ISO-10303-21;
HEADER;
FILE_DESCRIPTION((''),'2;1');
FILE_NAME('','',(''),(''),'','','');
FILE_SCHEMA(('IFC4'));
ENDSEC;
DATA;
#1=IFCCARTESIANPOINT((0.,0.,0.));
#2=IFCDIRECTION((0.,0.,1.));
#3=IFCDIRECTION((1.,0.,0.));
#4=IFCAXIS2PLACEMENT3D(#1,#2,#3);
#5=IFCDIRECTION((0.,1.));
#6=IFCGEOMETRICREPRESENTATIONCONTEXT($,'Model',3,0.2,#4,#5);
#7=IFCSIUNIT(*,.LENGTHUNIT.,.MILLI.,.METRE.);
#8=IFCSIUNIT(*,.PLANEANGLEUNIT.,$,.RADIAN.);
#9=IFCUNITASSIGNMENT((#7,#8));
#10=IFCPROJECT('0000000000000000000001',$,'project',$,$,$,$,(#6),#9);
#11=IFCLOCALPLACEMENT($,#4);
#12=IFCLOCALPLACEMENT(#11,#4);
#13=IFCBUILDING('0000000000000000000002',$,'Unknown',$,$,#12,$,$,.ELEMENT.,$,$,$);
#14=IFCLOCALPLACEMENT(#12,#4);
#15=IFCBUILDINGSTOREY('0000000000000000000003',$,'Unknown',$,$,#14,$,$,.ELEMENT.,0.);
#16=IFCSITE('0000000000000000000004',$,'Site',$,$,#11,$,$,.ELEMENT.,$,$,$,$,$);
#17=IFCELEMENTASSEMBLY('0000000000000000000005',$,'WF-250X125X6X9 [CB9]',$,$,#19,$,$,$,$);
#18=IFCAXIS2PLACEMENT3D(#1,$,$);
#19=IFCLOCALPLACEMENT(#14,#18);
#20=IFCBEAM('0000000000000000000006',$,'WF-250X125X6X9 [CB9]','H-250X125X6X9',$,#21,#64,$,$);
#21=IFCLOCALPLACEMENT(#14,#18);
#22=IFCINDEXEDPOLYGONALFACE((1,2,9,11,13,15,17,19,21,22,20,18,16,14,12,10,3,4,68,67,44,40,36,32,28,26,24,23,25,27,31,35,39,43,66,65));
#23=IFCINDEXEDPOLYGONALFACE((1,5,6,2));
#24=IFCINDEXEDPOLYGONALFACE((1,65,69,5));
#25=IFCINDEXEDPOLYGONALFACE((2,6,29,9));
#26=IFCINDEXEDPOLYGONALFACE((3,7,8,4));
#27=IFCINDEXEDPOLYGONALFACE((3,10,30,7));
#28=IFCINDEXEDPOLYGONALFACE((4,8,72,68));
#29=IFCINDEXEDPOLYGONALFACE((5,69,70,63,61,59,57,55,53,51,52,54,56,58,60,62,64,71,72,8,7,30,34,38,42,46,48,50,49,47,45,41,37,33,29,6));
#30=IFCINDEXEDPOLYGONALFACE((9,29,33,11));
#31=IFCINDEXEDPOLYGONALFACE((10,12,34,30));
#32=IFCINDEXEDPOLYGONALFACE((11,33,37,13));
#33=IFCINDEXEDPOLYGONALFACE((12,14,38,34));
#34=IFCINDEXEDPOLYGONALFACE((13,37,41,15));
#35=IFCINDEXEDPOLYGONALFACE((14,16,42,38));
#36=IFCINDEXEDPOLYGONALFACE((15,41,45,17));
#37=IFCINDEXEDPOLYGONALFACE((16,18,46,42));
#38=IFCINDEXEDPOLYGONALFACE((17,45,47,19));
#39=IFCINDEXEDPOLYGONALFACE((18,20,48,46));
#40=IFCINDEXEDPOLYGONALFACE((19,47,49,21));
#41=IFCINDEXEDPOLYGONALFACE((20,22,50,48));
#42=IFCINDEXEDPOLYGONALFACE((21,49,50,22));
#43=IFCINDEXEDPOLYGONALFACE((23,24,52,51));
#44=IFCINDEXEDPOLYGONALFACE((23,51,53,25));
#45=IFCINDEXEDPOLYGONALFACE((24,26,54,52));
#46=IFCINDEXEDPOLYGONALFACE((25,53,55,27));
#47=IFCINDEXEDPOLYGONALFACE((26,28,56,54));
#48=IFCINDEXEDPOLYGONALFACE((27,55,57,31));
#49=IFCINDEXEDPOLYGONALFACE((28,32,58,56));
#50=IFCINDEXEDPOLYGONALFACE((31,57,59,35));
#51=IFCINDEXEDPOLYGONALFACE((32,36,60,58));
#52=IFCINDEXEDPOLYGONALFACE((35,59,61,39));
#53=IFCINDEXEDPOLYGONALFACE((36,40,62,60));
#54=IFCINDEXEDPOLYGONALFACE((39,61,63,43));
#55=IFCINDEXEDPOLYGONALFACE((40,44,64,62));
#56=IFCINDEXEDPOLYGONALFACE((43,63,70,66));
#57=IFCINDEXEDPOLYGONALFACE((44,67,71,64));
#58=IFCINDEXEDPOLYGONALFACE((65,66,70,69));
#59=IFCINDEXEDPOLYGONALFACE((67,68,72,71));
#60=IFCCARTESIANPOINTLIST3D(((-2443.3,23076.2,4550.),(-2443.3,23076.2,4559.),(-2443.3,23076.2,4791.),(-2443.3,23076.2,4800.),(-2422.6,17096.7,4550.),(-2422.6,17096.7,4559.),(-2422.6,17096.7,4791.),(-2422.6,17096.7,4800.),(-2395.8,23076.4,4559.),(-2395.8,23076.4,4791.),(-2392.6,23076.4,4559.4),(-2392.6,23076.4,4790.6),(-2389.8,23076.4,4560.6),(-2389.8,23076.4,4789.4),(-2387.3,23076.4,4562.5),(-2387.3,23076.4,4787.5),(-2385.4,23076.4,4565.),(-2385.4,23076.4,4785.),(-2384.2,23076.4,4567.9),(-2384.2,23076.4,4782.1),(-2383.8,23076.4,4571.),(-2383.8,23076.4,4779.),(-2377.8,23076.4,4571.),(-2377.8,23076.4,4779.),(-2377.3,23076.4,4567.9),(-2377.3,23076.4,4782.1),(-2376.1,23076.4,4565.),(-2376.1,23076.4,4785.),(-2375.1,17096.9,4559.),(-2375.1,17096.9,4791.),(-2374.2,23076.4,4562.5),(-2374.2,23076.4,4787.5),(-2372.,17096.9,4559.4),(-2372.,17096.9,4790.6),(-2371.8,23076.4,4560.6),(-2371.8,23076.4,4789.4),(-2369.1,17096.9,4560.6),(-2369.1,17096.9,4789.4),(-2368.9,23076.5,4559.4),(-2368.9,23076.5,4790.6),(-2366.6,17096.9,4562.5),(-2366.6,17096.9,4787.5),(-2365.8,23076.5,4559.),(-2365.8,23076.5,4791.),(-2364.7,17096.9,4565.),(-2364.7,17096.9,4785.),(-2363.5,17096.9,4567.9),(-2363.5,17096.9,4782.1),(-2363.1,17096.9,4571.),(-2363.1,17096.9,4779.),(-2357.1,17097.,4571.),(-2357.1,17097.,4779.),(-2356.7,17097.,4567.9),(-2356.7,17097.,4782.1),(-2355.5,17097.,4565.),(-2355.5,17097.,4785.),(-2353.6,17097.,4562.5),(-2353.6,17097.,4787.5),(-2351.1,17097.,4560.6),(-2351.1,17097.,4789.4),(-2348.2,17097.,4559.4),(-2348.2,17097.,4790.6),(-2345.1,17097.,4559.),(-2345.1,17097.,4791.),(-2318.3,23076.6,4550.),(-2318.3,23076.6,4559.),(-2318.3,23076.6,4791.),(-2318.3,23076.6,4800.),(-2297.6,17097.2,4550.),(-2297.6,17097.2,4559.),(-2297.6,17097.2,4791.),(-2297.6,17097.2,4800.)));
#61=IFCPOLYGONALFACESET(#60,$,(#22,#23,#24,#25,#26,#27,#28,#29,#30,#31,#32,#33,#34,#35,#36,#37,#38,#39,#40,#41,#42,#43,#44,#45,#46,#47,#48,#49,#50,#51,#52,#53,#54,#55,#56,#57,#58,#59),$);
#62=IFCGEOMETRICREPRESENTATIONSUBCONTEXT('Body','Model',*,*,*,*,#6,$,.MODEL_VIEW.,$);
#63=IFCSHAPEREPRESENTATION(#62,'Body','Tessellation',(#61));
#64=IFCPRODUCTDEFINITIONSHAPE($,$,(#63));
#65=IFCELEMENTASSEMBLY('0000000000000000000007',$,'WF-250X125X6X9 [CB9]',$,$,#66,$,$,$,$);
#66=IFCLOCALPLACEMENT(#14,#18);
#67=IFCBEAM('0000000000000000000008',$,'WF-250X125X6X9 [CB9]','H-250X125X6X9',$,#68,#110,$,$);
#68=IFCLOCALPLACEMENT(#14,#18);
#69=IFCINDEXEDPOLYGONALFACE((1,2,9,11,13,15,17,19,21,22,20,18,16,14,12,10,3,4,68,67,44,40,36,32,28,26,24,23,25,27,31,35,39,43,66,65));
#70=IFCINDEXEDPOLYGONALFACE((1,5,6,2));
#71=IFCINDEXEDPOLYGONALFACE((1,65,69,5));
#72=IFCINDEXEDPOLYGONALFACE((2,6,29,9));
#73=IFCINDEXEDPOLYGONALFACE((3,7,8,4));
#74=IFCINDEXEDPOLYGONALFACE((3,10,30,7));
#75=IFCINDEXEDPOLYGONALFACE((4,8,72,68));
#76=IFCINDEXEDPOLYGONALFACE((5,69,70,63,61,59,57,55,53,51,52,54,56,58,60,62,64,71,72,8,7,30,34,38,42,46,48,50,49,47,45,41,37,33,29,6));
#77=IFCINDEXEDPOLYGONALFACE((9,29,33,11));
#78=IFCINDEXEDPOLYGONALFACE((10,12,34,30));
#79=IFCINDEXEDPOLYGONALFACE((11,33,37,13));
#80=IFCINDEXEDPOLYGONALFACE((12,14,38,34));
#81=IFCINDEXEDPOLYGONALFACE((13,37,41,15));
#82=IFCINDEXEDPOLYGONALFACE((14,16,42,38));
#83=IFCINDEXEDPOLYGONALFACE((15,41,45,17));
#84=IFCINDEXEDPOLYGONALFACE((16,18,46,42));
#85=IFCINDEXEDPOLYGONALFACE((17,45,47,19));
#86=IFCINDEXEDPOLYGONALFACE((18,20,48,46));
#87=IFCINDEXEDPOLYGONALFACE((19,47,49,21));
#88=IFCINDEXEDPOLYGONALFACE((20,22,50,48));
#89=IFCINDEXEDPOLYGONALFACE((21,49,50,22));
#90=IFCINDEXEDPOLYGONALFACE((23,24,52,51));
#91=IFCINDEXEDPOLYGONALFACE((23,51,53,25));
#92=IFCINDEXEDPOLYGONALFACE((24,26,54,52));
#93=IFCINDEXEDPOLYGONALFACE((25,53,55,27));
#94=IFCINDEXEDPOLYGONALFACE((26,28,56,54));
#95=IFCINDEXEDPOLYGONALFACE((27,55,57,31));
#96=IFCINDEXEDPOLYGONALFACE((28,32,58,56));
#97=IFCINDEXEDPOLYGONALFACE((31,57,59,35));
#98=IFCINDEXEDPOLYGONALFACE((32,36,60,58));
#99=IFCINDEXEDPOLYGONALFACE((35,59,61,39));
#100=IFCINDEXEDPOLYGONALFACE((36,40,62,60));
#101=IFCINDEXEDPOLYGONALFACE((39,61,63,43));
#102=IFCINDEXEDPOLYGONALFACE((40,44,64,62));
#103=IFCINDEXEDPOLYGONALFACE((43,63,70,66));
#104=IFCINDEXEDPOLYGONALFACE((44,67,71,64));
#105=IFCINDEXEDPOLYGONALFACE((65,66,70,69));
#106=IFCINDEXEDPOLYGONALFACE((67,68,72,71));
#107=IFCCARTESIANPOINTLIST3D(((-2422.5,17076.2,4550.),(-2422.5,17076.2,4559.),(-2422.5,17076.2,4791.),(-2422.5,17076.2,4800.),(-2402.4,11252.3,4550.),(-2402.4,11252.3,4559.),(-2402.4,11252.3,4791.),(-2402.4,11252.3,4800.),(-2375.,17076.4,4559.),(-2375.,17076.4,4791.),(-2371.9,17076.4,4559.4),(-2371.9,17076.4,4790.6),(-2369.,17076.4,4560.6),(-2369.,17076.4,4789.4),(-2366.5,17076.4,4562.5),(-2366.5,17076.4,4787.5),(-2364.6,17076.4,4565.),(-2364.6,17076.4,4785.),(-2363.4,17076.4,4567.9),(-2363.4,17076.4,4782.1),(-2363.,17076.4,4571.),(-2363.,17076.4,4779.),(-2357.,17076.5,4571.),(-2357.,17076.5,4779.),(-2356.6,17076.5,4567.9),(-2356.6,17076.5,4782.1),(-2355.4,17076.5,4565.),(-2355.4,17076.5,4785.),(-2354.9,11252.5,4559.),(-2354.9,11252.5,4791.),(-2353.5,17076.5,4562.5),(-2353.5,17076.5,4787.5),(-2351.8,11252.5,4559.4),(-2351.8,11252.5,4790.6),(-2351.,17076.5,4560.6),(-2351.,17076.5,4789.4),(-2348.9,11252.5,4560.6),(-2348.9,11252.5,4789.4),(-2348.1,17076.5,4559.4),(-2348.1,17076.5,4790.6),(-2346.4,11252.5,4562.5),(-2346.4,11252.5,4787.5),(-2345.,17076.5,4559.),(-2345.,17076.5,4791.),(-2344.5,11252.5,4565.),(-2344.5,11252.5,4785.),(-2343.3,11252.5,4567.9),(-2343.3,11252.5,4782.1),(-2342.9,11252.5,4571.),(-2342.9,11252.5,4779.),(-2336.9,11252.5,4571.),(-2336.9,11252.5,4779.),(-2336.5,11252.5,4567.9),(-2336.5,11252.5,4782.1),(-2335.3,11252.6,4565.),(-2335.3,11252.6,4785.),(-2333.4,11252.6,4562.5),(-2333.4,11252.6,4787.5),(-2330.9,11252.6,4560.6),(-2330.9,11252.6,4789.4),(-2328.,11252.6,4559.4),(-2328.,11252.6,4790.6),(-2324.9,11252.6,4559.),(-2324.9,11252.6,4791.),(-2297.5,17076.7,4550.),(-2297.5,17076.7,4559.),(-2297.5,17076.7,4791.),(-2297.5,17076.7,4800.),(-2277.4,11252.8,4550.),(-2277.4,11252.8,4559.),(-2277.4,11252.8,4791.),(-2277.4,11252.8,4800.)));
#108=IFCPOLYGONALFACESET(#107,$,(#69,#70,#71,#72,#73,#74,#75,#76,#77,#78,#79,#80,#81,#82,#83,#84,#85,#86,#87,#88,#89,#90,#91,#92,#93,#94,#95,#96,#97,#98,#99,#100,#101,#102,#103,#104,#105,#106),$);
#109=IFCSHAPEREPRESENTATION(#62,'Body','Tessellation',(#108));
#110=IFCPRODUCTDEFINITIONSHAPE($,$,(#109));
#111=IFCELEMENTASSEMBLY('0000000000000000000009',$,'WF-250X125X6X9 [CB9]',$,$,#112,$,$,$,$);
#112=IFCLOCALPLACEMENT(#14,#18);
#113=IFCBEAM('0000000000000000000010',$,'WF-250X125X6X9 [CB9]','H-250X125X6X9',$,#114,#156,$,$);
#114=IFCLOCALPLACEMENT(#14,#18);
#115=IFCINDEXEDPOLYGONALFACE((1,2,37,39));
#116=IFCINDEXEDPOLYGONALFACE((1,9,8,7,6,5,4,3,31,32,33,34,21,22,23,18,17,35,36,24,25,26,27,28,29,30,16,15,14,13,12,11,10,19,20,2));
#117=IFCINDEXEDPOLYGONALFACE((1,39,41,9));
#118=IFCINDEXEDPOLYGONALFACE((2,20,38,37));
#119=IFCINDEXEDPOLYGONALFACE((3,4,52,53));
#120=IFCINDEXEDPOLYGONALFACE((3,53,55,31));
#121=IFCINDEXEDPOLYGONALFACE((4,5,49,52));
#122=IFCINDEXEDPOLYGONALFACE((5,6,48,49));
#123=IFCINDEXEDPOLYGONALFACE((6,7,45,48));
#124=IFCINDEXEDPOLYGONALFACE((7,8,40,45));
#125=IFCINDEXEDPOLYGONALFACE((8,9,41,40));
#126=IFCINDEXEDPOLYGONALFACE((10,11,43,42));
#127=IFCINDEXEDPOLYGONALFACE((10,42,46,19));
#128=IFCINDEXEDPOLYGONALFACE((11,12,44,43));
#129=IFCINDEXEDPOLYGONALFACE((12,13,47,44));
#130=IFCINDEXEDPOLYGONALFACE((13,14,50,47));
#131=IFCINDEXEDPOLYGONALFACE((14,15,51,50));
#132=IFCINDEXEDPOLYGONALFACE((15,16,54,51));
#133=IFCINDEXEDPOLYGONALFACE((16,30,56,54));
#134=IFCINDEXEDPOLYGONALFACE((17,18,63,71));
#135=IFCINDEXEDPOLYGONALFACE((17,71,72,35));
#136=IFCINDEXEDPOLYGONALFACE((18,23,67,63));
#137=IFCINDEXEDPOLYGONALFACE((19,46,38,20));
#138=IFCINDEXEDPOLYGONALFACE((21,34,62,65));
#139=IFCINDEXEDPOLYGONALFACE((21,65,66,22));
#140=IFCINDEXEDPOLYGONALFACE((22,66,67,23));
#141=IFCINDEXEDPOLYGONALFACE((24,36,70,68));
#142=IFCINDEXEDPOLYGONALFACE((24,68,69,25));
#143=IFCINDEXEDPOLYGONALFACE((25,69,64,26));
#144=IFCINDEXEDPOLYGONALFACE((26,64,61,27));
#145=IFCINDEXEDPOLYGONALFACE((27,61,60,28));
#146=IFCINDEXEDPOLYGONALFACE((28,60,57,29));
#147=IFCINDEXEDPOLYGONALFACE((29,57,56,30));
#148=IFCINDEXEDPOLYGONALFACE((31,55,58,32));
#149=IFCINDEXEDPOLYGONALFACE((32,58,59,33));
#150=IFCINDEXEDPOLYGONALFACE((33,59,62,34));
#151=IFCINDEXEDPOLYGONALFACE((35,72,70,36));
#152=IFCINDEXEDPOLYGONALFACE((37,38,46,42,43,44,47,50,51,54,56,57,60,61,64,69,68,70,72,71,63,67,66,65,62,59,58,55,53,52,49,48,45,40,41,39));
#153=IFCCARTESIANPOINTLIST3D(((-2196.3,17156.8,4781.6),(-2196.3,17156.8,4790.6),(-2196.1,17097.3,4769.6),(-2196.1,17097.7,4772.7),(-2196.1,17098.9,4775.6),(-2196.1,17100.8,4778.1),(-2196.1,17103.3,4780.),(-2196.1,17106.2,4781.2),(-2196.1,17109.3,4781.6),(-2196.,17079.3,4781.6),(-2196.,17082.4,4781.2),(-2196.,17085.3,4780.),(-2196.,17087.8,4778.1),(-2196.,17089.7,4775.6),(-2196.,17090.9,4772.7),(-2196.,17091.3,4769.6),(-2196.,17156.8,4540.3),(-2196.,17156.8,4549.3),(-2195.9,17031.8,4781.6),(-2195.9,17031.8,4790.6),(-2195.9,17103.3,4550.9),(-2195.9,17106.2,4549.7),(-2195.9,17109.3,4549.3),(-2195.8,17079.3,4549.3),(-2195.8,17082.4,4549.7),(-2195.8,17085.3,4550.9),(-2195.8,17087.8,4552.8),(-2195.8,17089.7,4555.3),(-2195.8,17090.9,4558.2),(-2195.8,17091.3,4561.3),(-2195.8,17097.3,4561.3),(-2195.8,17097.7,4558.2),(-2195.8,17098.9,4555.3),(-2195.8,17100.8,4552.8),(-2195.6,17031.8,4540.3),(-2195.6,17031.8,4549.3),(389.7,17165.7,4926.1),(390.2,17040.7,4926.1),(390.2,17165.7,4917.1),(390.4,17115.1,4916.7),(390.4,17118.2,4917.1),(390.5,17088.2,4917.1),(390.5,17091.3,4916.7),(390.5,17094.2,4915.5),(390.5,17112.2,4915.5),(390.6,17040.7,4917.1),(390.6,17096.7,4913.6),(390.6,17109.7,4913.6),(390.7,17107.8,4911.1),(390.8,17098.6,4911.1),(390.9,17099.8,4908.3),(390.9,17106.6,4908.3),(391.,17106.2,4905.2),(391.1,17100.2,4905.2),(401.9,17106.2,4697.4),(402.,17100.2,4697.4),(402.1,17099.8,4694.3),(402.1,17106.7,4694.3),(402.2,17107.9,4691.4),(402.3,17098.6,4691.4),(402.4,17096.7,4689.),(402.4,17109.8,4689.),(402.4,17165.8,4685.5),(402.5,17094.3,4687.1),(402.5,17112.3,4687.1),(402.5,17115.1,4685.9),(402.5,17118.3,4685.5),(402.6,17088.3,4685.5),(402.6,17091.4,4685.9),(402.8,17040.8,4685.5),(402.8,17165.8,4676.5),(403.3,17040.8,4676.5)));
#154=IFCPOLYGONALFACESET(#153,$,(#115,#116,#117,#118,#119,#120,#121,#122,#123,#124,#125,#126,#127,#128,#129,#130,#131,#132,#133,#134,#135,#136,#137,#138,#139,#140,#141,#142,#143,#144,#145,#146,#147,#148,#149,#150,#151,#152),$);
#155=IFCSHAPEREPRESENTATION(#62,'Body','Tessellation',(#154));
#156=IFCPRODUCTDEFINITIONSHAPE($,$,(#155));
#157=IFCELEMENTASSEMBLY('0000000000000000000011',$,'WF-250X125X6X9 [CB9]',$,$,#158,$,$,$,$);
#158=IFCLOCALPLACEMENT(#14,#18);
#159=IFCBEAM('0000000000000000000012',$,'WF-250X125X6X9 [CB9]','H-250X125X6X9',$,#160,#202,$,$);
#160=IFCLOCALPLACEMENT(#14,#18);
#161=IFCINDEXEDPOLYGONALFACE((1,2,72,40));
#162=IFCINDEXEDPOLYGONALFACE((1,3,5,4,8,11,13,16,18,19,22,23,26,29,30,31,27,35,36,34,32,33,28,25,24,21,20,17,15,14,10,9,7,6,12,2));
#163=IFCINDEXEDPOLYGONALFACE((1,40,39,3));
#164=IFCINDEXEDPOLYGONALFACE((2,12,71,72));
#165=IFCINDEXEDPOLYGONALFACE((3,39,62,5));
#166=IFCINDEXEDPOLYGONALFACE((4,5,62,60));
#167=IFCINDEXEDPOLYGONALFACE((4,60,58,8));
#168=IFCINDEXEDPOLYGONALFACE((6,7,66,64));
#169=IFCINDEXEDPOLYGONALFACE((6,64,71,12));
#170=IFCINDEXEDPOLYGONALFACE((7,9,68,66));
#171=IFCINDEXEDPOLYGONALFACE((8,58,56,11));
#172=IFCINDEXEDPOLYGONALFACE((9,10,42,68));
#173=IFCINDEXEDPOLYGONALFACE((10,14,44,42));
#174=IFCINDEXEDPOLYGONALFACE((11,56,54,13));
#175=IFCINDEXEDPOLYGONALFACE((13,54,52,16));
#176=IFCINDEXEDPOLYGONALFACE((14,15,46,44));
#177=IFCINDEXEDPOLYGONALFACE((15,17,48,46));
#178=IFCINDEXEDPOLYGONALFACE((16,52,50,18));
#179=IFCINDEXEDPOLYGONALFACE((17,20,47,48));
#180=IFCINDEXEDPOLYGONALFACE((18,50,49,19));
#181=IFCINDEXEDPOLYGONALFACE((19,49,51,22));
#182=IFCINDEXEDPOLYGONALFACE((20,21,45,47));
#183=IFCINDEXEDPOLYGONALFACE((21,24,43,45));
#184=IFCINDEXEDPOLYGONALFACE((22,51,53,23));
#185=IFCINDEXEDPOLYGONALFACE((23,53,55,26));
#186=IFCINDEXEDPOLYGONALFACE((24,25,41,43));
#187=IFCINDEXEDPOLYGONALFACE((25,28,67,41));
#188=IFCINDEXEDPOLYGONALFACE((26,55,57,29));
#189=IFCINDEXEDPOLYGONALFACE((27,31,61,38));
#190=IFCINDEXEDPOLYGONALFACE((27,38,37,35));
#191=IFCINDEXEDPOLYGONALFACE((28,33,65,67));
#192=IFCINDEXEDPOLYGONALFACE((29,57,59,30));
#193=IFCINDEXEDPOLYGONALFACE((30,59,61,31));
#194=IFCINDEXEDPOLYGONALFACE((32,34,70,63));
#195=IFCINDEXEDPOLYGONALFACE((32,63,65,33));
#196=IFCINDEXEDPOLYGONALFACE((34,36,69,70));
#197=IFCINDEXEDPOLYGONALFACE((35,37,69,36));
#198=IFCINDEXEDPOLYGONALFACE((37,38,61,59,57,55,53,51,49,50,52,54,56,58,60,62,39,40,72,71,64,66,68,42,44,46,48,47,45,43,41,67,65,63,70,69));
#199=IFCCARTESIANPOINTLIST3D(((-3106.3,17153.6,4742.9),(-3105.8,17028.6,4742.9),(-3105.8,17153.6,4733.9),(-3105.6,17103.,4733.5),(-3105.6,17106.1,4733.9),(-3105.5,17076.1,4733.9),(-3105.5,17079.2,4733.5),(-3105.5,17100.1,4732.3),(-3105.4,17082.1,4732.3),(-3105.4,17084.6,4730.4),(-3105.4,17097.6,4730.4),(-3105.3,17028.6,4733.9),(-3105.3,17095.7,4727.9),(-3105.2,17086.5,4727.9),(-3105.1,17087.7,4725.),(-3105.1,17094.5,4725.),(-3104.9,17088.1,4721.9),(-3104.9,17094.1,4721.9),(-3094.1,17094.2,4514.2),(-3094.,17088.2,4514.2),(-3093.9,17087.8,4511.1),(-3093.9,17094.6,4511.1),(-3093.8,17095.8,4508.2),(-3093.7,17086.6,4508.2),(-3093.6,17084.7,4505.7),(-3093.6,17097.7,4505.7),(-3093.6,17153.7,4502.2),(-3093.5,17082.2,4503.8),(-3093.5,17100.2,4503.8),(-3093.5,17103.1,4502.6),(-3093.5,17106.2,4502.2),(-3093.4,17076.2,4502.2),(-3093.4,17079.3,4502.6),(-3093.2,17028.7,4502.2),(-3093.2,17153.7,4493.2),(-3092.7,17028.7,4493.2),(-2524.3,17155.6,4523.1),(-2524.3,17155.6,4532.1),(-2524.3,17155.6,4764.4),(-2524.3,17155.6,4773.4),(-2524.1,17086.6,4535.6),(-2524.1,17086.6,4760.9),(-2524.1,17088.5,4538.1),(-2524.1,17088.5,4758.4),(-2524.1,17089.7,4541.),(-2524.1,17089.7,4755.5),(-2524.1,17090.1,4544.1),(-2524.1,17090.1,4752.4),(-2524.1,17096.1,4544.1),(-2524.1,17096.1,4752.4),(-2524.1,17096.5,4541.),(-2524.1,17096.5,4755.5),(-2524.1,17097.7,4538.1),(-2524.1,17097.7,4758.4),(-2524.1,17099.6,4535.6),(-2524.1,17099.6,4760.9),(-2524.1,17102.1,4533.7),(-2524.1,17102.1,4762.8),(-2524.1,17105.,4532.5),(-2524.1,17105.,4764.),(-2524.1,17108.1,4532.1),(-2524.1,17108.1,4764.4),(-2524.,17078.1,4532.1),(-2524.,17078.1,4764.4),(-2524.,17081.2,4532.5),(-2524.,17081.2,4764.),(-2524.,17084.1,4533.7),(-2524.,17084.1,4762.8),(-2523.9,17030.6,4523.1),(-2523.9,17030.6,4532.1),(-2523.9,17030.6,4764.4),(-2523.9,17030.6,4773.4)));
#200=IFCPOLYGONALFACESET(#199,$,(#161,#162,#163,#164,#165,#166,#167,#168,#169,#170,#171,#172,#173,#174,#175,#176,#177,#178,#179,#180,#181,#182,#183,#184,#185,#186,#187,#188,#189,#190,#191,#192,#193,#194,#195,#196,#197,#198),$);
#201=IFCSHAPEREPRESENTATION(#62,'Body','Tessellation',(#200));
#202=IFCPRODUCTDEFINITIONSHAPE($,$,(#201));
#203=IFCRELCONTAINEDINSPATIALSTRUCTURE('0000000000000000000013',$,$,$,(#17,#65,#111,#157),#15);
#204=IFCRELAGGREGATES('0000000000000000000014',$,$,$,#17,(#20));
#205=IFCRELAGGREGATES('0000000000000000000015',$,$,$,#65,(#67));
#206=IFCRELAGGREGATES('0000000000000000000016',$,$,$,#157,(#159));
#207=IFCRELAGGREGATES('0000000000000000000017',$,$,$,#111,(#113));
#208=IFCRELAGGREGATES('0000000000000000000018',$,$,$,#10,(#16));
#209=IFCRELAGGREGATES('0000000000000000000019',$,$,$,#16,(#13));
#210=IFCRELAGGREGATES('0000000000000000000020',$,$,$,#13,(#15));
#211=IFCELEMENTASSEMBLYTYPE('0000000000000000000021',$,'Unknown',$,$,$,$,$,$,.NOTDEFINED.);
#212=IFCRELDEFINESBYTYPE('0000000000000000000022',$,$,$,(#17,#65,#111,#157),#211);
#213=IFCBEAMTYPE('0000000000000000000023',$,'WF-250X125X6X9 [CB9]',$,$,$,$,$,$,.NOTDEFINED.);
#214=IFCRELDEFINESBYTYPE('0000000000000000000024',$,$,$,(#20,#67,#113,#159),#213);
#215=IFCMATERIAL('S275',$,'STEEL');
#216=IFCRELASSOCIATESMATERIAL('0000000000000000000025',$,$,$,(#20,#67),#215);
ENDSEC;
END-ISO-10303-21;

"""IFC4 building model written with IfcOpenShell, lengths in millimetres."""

from ifc_helpers import new_model, si_unit, direction, frame, origin_with_axes, origin_2d_with_axis, place, context, subcontext, project, spatial, i_section, extrude, clip, halfspace, material, material_profile, profile_set, profile_usage, type_object, element, aggregate, save


model = new_model("IFC4")

# Units and contexts
model_context = context("Model", 3, precision=0.2, world=origin_with_axes(), true_north=direction((0.0, 1.0)))
body_context = subcontext(model_context, "Body", "Model", "MODEL_VIEW")
ifc_project = project(units=[si_unit("LENGTHUNIT", "METRE", prefix="MILLI"), si_unit("PLANEANGLEUNIT", "RADIAN")], contexts=[model_context])

# Site, building, storey
site_placement = place(None, origin_with_axes())
site = spatial("IfcSite", under=ifc_project, at=site_placement, Name="Site", CompositionType="ELEMENT")
building_placement = place(site_placement, origin_with_axes())
building = spatial("IfcBuilding", under=site, at=building_placement, Name="Unknown", CompositionType="ELEMENT")
storey_placement = place(building_placement, origin_with_axes())
storey = spatial("IfcBuildingStorey", under=building, at=storey_placement, Name="Unknown", CompositionType="ELEMENT", Elevation=0.0)

# Element assemblies, beams
element_assembly_type = type_object("IfcElementAssemblyType", Name="Unknown", PredefinedType="NOTDEFINED")
assembly_1_placement = place(storey_placement, frame((-2360.1, 17097.0, 4675.0), z_axis=(0.999994, 0.003456, 0.0), x_axis=(-0.003456, 0.999994, 0.0)))
assembly_1 = element("IfcElementAssembly", 1, at=assembly_1_placement, inside=storey, type_object=element_assembly_type, Name="WF-250X125X6X9 [CB9]")
ifc_material_1 = material(Name="S275", Category="STEEL")
ifc_material_profile_1 = material_profile(ifc_material_1, i_section(OverallWidth=125.0, OverallDepth=250.0, WebThickness=6.0, FlangeThickness=9.0, FilletRadius=12.0, FlangeEdgeRadius=0.0, FlangeSlope=0.0, at=origin_2d_with_axis()), Name="H-250X125X6X9")
ifc_profile_set_1 = profile_set([ifc_material_profile_1])
ifc_profile_usage_1 = profile_usage(ifc_profile_set_1, cardinal=8)
beam_type_1 = type_object("IfcBeamType", Name="WF-250X125X6X9 [CB9]", PredefinedType="NOTDEFINED")
beam_1_placement = place(assembly_1_placement, origin_with_axes())
beam_1 = element("IfcBeam", 2, at=beam_1_placement, type_object=beam_type_1, material=ifc_profile_usage_1, Name="WF-250X125X6X9 [CB9]", Description="H-250X125X6X9", context=body_context, shape_type="SolidModel", body=[
    extrude(i_section(OverallWidth=125.0, OverallDepth=250.0, WebThickness=6.0, FlangeThickness=9.0, FilletRadius=12.0, FlangeEdgeRadius=0.0, FlangeSlope=0.0, at=origin_2d_with_axis()), frame((0.0, 0.0, 0.0), z_axis=(-1.0, 0.0, 0.0), x_axis=(0.0, 0.0, 1.0)), (0.0, 0.0, -1.0), 5979.5),
])
aggregate(assembly_1, [beam_1])
assembly_2_placement = place(storey_placement, frame((-2360.0, 17076.5, 4675.0), z_axis=(-0.999994, -0.003456, 0.0), x_axis=(0.003456, -0.999994, 0.0)))
assembly_2 = element("IfcElementAssembly", 3, at=assembly_2_placement, inside=storey, type_object=element_assembly_type, Name="WF-250X125X6X9 [CB9]")
beam_2_placement = place(assembly_2_placement, origin_with_axes())
beam_2 = element("IfcBeam", 4, at=beam_2_placement, type_object=beam_type_1, material=ifc_profile_usage_1, Name="WF-250X125X6X9 [CB9]", Description="H-250X125X6X9", context=body_context, shape_type="SolidModel", body=[
    extrude(i_section(OverallWidth=125.0, OverallDepth=250.0, WebThickness=6.0, FlangeThickness=9.0, FilletRadius=12.0, FlangeEdgeRadius=0.0, FlangeSlope=0.0, at=origin_2d_with_axis()), frame((0.0, 0.0, 0.0), z_axis=(-1.0, 0.0, 0.0), x_axis=(0.0, 0.0, 1.0)), (0.0, 0.0, -1.0), 5824.0),
])
aggregate(assembly_2, [beam_2])
assembly_3_placement = place(storey_placement, frame((-2248.2, 17094.1, 4662.7), z_axis=(0.003456, -0.999994, 0.0), x_axis=(0.998624, 0.003452, 0.052336)))
assembly_3 = element("IfcElementAssembly", 5, at=assembly_3_placement, inside=storey, type_object=element_assembly_type, Name="WF-250X125X6X9 [CB9]")
beam_3_placement = place(assembly_3_placement, origin_with_axes())
beam_3 = element("IfcBeam", 6, at=beam_3_placement, type_object=beam_type_1, Name="WF-250X125X6X9 [CB9]", Description="H-250X125X6X9", context=body_context, shape_type="Clipping", body=[
    clip(extrude(i_section(OverallWidth=125.0, OverallDepth=250.0, WebThickness=6.0, FlangeThickness=9.0, FilletRadius=12.0, FlangeEdgeRadius=0.0, FlangeSlope=0.0, at=origin_2d_with_axis()), frame((0.0, 0.0, 0.0), z_axis=(-1.0, 0.0, 0.0), x_axis=(0.0, 0.0, 1.0)), (0.0, 0.0, -1.0), 2648.3), halfspace(frame((45.9, -125.0, -62.5), z_axis=(-0.998684, 0.051283, 0.0), x_axis=(0.0, 0.0, 1.0)), False)),
])
assembly_4_placement = place(storey_placement, frame((-3099.5, 17091.1, 4618.1), z_axis=(0.003456, -0.999994, 0.0), x_axis=(0.998624, 0.003452, 0.052336)))
assembly_4 = element("IfcElementAssembly", 7, at=assembly_4_placement, inside=storey, type_object=element_assembly_type, Name="WF-250X125X6X9 [CB9]")
beam_4_placement = place(assembly_4_placement, origin_with_axes())
beam_4 = element("IfcBeam", 8, at=beam_4_placement, type_object=beam_type_1, Name="WF-250X125X6X9 [CB9]", Description="H-250X125X6X9", context=body_context, shape_type="Clipping", body=[
    clip(extrude(i_section(OverallWidth=125.0, OverallDepth=250.0, WebThickness=6.0, FlangeThickness=9.0, FilletRadius=12.0, FlangeEdgeRadius=0.0, FlangeSlope=0.0, at=origin_2d_with_axis()), frame((0.0, 0.0, 0.0), z_axis=(-1.0, 0.0, 0.0), x_axis=(0.0, 0.0, 1.0)), (0.0, 0.0, -1.0), 596.0), halfspace(frame((569.7, -125.0, 62.5), z_axis=(0.99863, -0.052336, 0.0), x_axis=(0.0, 0.0, -1.0)), False)),
])

aggregate(assembly_4, [beam_4])
aggregate(assembly_3, [beam_3])

save(model, "model.ifc")
